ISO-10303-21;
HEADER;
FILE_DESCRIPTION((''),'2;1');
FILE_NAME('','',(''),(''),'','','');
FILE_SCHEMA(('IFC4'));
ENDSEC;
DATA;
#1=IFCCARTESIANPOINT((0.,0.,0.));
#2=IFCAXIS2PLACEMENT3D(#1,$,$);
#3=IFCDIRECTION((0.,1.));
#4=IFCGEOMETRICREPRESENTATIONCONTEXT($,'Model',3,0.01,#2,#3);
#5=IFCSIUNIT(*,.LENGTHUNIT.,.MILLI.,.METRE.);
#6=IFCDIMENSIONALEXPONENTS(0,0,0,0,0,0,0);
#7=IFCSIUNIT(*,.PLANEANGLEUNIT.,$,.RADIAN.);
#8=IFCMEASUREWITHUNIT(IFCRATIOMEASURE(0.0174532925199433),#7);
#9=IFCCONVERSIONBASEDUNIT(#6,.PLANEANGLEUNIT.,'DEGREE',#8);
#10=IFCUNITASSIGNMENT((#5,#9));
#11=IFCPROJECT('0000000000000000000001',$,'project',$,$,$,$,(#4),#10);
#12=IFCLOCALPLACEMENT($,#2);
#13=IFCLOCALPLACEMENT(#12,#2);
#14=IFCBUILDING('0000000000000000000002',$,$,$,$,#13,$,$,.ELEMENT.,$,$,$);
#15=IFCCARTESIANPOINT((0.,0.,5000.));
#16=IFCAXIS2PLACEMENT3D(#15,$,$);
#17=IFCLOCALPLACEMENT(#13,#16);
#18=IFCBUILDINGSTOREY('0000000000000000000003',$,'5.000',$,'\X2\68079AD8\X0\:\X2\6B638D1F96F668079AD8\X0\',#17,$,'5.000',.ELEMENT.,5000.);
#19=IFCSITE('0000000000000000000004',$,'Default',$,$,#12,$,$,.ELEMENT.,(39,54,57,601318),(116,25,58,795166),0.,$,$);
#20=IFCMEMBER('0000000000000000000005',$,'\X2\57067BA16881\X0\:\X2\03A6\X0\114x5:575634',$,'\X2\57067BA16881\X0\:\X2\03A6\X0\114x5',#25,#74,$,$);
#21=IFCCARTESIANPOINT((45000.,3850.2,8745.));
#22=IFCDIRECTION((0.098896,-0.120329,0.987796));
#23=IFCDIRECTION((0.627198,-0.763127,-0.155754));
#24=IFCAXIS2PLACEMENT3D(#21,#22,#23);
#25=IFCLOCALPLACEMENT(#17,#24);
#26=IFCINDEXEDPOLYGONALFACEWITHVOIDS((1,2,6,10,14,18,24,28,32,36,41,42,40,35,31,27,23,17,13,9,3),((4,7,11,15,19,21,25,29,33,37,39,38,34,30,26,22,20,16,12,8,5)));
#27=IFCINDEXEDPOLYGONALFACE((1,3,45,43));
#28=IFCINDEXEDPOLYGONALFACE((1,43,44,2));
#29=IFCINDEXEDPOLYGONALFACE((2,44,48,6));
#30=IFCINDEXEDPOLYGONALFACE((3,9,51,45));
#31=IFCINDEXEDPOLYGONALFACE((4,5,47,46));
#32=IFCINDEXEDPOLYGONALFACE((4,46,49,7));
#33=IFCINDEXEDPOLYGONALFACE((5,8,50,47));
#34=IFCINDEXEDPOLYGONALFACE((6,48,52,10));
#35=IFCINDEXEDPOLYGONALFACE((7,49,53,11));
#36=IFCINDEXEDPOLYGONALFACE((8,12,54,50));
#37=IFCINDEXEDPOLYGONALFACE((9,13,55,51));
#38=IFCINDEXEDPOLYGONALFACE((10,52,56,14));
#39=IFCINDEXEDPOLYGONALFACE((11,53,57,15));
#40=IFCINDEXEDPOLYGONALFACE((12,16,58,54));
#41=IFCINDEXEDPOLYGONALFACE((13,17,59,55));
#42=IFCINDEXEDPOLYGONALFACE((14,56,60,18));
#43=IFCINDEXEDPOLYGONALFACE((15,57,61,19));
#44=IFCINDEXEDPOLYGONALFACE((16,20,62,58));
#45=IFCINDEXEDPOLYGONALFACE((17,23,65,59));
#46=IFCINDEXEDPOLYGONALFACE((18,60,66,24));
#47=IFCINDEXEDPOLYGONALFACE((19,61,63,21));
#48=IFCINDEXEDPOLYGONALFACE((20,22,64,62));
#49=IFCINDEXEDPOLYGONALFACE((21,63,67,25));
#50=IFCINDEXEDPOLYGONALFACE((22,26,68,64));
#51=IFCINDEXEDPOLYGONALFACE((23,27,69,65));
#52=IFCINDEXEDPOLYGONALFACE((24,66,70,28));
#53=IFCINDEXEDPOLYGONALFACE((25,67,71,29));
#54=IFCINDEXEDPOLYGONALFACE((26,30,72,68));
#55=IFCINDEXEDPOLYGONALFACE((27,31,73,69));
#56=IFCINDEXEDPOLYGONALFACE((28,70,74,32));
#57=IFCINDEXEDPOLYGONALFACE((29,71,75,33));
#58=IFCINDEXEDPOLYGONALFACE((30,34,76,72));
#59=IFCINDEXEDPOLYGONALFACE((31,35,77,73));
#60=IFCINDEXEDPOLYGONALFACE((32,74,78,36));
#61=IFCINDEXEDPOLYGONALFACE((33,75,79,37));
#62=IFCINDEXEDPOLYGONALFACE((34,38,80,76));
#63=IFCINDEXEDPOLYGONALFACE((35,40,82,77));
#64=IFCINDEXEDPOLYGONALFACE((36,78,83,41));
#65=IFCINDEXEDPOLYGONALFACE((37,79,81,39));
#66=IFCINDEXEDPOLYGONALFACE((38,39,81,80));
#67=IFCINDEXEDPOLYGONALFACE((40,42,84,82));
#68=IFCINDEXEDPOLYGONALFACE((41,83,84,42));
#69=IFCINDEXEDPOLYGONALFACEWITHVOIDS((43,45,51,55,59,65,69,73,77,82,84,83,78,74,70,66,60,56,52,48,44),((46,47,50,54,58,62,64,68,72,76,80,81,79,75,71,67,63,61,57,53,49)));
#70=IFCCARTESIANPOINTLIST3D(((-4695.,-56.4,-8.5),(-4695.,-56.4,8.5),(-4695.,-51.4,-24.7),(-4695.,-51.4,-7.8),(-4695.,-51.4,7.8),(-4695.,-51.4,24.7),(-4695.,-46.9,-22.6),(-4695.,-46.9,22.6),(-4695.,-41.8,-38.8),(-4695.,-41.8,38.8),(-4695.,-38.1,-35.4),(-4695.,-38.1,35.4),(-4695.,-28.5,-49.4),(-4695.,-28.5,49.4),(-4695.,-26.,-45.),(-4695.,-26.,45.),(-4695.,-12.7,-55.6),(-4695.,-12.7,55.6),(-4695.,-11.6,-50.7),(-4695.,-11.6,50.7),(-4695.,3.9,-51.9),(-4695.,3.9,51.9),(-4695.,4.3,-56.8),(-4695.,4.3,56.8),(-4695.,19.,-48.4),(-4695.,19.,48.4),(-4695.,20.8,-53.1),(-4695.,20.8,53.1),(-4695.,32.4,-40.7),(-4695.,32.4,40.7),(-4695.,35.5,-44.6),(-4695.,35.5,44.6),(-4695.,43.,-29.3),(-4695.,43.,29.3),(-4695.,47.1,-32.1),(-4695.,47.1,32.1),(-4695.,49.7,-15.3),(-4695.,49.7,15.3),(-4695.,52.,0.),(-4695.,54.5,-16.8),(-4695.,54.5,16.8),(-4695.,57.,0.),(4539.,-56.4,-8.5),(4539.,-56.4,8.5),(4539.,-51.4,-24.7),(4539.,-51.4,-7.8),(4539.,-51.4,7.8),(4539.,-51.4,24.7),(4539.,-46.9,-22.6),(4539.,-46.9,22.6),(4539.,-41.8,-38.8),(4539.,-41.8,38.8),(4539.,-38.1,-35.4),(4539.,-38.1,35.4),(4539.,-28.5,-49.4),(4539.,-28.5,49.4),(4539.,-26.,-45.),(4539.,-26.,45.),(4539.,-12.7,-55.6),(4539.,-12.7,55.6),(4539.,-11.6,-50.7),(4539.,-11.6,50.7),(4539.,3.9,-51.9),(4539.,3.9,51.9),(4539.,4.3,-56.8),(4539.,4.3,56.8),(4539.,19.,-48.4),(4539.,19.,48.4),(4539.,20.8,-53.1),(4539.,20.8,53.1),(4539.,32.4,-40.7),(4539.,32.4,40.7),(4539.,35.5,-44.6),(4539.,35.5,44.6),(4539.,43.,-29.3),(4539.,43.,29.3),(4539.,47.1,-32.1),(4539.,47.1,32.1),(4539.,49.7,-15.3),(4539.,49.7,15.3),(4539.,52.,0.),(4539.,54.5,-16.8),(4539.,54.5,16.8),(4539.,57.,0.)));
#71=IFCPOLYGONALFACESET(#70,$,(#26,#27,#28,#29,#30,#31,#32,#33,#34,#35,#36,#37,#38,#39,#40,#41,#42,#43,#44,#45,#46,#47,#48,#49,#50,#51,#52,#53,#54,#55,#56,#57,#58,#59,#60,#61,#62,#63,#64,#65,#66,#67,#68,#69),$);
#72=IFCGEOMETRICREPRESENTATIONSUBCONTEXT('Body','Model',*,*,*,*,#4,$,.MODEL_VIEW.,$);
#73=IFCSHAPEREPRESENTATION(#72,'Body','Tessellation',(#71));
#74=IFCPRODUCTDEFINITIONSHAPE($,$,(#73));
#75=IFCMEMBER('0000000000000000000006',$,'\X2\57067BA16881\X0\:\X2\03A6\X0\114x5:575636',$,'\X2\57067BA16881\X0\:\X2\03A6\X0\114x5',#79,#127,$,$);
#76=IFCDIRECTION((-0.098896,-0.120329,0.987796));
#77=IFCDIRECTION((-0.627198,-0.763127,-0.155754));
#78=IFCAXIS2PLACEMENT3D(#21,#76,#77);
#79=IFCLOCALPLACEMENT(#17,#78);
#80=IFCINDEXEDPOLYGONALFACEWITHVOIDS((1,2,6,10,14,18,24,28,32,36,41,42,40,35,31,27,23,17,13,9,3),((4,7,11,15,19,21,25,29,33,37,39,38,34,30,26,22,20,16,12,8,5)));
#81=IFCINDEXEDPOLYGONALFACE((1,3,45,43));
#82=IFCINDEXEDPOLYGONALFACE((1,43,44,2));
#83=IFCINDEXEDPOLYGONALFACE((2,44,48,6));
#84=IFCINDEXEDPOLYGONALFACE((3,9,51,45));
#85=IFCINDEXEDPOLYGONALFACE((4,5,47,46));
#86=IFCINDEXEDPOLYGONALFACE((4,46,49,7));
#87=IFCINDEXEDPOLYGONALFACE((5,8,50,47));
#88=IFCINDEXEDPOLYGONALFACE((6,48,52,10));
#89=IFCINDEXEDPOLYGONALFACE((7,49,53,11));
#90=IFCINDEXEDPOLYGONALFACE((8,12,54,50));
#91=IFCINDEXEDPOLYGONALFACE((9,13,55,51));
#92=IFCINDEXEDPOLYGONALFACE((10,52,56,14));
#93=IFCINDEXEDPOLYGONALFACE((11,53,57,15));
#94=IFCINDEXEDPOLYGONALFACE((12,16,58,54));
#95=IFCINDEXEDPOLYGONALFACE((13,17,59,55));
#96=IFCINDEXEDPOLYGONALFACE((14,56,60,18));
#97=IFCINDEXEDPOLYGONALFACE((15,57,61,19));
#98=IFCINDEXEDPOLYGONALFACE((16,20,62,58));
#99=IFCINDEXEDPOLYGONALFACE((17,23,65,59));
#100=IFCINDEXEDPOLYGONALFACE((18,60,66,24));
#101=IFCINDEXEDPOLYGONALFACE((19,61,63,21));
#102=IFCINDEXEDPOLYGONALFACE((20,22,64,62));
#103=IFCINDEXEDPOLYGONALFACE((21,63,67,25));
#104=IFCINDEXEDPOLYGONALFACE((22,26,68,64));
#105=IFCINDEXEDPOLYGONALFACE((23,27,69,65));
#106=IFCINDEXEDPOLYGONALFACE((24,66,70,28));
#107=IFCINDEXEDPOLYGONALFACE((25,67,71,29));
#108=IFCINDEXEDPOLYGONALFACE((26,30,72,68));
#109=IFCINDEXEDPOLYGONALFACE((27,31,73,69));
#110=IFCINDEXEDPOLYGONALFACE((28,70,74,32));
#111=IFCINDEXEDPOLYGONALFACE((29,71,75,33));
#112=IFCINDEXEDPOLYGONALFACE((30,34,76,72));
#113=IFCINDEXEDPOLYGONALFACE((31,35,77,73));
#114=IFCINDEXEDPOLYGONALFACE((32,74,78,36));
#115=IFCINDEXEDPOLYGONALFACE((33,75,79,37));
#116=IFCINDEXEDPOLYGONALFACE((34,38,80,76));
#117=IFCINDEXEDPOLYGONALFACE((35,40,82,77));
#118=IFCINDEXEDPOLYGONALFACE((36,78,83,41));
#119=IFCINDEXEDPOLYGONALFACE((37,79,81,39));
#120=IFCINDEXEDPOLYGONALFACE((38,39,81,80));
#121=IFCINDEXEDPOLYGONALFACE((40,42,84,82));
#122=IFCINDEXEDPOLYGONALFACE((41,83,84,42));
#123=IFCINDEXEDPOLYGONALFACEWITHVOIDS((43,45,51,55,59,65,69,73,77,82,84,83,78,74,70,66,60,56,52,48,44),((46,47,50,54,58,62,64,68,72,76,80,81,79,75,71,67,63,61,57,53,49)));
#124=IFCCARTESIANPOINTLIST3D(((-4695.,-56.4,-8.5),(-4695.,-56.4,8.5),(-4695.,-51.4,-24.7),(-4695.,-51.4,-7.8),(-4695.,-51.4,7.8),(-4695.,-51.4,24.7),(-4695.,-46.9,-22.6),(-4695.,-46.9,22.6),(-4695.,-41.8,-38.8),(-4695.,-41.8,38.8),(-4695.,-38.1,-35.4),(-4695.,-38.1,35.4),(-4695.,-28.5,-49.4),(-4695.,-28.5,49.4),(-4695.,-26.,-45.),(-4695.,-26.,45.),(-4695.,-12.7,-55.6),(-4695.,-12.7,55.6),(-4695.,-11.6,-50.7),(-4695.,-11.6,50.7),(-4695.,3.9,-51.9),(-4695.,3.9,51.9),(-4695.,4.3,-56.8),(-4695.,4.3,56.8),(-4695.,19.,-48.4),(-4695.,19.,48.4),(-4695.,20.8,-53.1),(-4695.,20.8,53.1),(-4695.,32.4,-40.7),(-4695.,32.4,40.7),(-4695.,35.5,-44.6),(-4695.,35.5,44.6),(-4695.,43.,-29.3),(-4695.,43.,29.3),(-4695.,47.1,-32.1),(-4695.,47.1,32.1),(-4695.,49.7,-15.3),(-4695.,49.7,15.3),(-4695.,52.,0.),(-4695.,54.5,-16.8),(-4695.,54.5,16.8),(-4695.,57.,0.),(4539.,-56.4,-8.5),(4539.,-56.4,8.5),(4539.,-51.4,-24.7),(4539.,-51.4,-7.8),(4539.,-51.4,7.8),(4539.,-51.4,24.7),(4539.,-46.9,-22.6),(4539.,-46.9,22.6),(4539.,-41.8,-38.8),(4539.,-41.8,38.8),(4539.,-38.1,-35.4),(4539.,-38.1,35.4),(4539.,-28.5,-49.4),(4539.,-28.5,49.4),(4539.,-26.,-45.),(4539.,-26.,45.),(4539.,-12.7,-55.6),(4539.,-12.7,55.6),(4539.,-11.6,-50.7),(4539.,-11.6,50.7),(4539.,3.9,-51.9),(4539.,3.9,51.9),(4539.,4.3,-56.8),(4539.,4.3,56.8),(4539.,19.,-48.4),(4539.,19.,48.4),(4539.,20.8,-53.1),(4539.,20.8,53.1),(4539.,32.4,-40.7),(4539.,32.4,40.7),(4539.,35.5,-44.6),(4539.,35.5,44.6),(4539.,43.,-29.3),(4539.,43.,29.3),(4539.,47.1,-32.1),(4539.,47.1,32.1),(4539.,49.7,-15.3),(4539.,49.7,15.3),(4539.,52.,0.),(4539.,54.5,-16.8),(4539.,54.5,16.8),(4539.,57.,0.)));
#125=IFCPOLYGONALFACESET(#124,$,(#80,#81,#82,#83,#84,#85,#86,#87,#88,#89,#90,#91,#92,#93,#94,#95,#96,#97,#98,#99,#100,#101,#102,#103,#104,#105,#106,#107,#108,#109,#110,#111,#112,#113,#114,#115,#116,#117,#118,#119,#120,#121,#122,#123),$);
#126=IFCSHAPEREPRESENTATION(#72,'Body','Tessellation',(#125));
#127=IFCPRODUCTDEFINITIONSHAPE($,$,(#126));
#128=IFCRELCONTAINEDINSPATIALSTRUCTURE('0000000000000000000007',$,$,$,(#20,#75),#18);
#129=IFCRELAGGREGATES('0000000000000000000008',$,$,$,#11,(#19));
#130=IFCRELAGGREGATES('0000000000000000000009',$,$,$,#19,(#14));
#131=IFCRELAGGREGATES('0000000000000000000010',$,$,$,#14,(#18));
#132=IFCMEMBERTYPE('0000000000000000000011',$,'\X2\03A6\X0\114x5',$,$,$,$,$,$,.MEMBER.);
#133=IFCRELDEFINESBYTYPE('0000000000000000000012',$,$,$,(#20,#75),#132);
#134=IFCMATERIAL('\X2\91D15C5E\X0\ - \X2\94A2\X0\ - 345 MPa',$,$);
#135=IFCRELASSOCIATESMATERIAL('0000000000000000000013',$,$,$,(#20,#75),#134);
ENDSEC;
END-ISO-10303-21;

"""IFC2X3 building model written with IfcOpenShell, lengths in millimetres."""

from ifc_helpers import new_model, entity, si_unit, converted_unit, direction, frame, frame_2d, origin, place, context, subcontext, project, spatial, hollow_circle, extrude, source, transform, mapped, material, type_object, type_shapes, element, save


model = new_model("IFC2X3")

# Units and contexts
model_context = context("Model", 3, precision=0.01, world=origin(), true_north=direction((0.0, 1.0)))
body_context = subcontext(model_context, "Body", "Model", "MODEL_VIEW")
ifc_project = project(units=[si_unit("LENGTHUNIT", "METRE", prefix="MILLI"), converted_unit("PLANEANGLEUNIT", "DEGREE", entity("IfcRatioMeasure", 0.0174532925199433), si_unit("PLANEANGLEUNIT", "RADIAN"), dimensions=[0, 0, 0, 0, 0, 0, 0])], contexts=[model_context])

# Site, building, storey
site_placement = place(None, origin())
site = spatial("IfcSite", under=ifc_project, at=site_placement, Name="Default", CompositionType="ELEMENT", RefLatitude=(39, 54, 57, 601318), RefLongitude=(116, 25, 58, 795166), RefElevation=0.0)
building_placement = place(site_placement, origin())
building = spatial("IfcBuilding", under=site, at=building_placement, CompositionType="ELEMENT")
storey_placement = place(building_placement, frame((0.0, 0.0, 5000.0)))
storey = spatial("IfcBuildingStorey", under=building, at=storey_placement, Name="5.000", ObjectType="标高:正负零标高", LongName="5.000", CompositionType="ELEMENT", Elevation=5000.0)

# Members
ifc_material_1 = material(Name="金属 - 钢 - 345 MPa")
member_type_1 = type_object("IfcMemberType", Name="Φ114x5", PredefinedType="MEMBER")
shared_shape_1 = source(origin(), body_context, "Body", "SweptSolid", [
    extrude(hollow_circle(Radius=57.0, WallThickness=5.0, at=frame_2d((0.0, 0.0), x_axis=(1.0, 0.0))), frame((-4695.0, 0.0, 0.0), z_axis=(1.0, 0.0, 0.0), x_axis=(0.0, 1.0, 0.0)), (0.0, 0.0, 1.0), 9234.0),
])
type_shapes(member_type_1, [shared_shape_1])
for number, where, z_axis, x_axis, name in (
    (1, (45000.0, 3850.2, 8745.0), (0.098896, -0.120329, 0.987796), (0.627198, -0.763127, -0.155754), "圆管梁:Φ114x5:575634"),
    (2, (45000.0, 3850.2, 8745.0), (-0.098896, -0.120329, 0.987796), (-0.627198, -0.763127, -0.155754), "圆管梁:Φ114x5:575636"),
):
    element("IfcMember", number, at=place(storey_placement, frame(where, z_axis=z_axis, x_axis=x_axis)), inside=storey, type_object=member_type_1, material=ifc_material_1, Name=name, ObjectType="圆管梁:Φ114x5", context=body_context, shape_type="MappedRepresentation", body=[
        mapped(shared_shape_1, transform((0.0, 0.0, 0.0), scale=1.0)),
    ])

save(model, "model.ifc")
